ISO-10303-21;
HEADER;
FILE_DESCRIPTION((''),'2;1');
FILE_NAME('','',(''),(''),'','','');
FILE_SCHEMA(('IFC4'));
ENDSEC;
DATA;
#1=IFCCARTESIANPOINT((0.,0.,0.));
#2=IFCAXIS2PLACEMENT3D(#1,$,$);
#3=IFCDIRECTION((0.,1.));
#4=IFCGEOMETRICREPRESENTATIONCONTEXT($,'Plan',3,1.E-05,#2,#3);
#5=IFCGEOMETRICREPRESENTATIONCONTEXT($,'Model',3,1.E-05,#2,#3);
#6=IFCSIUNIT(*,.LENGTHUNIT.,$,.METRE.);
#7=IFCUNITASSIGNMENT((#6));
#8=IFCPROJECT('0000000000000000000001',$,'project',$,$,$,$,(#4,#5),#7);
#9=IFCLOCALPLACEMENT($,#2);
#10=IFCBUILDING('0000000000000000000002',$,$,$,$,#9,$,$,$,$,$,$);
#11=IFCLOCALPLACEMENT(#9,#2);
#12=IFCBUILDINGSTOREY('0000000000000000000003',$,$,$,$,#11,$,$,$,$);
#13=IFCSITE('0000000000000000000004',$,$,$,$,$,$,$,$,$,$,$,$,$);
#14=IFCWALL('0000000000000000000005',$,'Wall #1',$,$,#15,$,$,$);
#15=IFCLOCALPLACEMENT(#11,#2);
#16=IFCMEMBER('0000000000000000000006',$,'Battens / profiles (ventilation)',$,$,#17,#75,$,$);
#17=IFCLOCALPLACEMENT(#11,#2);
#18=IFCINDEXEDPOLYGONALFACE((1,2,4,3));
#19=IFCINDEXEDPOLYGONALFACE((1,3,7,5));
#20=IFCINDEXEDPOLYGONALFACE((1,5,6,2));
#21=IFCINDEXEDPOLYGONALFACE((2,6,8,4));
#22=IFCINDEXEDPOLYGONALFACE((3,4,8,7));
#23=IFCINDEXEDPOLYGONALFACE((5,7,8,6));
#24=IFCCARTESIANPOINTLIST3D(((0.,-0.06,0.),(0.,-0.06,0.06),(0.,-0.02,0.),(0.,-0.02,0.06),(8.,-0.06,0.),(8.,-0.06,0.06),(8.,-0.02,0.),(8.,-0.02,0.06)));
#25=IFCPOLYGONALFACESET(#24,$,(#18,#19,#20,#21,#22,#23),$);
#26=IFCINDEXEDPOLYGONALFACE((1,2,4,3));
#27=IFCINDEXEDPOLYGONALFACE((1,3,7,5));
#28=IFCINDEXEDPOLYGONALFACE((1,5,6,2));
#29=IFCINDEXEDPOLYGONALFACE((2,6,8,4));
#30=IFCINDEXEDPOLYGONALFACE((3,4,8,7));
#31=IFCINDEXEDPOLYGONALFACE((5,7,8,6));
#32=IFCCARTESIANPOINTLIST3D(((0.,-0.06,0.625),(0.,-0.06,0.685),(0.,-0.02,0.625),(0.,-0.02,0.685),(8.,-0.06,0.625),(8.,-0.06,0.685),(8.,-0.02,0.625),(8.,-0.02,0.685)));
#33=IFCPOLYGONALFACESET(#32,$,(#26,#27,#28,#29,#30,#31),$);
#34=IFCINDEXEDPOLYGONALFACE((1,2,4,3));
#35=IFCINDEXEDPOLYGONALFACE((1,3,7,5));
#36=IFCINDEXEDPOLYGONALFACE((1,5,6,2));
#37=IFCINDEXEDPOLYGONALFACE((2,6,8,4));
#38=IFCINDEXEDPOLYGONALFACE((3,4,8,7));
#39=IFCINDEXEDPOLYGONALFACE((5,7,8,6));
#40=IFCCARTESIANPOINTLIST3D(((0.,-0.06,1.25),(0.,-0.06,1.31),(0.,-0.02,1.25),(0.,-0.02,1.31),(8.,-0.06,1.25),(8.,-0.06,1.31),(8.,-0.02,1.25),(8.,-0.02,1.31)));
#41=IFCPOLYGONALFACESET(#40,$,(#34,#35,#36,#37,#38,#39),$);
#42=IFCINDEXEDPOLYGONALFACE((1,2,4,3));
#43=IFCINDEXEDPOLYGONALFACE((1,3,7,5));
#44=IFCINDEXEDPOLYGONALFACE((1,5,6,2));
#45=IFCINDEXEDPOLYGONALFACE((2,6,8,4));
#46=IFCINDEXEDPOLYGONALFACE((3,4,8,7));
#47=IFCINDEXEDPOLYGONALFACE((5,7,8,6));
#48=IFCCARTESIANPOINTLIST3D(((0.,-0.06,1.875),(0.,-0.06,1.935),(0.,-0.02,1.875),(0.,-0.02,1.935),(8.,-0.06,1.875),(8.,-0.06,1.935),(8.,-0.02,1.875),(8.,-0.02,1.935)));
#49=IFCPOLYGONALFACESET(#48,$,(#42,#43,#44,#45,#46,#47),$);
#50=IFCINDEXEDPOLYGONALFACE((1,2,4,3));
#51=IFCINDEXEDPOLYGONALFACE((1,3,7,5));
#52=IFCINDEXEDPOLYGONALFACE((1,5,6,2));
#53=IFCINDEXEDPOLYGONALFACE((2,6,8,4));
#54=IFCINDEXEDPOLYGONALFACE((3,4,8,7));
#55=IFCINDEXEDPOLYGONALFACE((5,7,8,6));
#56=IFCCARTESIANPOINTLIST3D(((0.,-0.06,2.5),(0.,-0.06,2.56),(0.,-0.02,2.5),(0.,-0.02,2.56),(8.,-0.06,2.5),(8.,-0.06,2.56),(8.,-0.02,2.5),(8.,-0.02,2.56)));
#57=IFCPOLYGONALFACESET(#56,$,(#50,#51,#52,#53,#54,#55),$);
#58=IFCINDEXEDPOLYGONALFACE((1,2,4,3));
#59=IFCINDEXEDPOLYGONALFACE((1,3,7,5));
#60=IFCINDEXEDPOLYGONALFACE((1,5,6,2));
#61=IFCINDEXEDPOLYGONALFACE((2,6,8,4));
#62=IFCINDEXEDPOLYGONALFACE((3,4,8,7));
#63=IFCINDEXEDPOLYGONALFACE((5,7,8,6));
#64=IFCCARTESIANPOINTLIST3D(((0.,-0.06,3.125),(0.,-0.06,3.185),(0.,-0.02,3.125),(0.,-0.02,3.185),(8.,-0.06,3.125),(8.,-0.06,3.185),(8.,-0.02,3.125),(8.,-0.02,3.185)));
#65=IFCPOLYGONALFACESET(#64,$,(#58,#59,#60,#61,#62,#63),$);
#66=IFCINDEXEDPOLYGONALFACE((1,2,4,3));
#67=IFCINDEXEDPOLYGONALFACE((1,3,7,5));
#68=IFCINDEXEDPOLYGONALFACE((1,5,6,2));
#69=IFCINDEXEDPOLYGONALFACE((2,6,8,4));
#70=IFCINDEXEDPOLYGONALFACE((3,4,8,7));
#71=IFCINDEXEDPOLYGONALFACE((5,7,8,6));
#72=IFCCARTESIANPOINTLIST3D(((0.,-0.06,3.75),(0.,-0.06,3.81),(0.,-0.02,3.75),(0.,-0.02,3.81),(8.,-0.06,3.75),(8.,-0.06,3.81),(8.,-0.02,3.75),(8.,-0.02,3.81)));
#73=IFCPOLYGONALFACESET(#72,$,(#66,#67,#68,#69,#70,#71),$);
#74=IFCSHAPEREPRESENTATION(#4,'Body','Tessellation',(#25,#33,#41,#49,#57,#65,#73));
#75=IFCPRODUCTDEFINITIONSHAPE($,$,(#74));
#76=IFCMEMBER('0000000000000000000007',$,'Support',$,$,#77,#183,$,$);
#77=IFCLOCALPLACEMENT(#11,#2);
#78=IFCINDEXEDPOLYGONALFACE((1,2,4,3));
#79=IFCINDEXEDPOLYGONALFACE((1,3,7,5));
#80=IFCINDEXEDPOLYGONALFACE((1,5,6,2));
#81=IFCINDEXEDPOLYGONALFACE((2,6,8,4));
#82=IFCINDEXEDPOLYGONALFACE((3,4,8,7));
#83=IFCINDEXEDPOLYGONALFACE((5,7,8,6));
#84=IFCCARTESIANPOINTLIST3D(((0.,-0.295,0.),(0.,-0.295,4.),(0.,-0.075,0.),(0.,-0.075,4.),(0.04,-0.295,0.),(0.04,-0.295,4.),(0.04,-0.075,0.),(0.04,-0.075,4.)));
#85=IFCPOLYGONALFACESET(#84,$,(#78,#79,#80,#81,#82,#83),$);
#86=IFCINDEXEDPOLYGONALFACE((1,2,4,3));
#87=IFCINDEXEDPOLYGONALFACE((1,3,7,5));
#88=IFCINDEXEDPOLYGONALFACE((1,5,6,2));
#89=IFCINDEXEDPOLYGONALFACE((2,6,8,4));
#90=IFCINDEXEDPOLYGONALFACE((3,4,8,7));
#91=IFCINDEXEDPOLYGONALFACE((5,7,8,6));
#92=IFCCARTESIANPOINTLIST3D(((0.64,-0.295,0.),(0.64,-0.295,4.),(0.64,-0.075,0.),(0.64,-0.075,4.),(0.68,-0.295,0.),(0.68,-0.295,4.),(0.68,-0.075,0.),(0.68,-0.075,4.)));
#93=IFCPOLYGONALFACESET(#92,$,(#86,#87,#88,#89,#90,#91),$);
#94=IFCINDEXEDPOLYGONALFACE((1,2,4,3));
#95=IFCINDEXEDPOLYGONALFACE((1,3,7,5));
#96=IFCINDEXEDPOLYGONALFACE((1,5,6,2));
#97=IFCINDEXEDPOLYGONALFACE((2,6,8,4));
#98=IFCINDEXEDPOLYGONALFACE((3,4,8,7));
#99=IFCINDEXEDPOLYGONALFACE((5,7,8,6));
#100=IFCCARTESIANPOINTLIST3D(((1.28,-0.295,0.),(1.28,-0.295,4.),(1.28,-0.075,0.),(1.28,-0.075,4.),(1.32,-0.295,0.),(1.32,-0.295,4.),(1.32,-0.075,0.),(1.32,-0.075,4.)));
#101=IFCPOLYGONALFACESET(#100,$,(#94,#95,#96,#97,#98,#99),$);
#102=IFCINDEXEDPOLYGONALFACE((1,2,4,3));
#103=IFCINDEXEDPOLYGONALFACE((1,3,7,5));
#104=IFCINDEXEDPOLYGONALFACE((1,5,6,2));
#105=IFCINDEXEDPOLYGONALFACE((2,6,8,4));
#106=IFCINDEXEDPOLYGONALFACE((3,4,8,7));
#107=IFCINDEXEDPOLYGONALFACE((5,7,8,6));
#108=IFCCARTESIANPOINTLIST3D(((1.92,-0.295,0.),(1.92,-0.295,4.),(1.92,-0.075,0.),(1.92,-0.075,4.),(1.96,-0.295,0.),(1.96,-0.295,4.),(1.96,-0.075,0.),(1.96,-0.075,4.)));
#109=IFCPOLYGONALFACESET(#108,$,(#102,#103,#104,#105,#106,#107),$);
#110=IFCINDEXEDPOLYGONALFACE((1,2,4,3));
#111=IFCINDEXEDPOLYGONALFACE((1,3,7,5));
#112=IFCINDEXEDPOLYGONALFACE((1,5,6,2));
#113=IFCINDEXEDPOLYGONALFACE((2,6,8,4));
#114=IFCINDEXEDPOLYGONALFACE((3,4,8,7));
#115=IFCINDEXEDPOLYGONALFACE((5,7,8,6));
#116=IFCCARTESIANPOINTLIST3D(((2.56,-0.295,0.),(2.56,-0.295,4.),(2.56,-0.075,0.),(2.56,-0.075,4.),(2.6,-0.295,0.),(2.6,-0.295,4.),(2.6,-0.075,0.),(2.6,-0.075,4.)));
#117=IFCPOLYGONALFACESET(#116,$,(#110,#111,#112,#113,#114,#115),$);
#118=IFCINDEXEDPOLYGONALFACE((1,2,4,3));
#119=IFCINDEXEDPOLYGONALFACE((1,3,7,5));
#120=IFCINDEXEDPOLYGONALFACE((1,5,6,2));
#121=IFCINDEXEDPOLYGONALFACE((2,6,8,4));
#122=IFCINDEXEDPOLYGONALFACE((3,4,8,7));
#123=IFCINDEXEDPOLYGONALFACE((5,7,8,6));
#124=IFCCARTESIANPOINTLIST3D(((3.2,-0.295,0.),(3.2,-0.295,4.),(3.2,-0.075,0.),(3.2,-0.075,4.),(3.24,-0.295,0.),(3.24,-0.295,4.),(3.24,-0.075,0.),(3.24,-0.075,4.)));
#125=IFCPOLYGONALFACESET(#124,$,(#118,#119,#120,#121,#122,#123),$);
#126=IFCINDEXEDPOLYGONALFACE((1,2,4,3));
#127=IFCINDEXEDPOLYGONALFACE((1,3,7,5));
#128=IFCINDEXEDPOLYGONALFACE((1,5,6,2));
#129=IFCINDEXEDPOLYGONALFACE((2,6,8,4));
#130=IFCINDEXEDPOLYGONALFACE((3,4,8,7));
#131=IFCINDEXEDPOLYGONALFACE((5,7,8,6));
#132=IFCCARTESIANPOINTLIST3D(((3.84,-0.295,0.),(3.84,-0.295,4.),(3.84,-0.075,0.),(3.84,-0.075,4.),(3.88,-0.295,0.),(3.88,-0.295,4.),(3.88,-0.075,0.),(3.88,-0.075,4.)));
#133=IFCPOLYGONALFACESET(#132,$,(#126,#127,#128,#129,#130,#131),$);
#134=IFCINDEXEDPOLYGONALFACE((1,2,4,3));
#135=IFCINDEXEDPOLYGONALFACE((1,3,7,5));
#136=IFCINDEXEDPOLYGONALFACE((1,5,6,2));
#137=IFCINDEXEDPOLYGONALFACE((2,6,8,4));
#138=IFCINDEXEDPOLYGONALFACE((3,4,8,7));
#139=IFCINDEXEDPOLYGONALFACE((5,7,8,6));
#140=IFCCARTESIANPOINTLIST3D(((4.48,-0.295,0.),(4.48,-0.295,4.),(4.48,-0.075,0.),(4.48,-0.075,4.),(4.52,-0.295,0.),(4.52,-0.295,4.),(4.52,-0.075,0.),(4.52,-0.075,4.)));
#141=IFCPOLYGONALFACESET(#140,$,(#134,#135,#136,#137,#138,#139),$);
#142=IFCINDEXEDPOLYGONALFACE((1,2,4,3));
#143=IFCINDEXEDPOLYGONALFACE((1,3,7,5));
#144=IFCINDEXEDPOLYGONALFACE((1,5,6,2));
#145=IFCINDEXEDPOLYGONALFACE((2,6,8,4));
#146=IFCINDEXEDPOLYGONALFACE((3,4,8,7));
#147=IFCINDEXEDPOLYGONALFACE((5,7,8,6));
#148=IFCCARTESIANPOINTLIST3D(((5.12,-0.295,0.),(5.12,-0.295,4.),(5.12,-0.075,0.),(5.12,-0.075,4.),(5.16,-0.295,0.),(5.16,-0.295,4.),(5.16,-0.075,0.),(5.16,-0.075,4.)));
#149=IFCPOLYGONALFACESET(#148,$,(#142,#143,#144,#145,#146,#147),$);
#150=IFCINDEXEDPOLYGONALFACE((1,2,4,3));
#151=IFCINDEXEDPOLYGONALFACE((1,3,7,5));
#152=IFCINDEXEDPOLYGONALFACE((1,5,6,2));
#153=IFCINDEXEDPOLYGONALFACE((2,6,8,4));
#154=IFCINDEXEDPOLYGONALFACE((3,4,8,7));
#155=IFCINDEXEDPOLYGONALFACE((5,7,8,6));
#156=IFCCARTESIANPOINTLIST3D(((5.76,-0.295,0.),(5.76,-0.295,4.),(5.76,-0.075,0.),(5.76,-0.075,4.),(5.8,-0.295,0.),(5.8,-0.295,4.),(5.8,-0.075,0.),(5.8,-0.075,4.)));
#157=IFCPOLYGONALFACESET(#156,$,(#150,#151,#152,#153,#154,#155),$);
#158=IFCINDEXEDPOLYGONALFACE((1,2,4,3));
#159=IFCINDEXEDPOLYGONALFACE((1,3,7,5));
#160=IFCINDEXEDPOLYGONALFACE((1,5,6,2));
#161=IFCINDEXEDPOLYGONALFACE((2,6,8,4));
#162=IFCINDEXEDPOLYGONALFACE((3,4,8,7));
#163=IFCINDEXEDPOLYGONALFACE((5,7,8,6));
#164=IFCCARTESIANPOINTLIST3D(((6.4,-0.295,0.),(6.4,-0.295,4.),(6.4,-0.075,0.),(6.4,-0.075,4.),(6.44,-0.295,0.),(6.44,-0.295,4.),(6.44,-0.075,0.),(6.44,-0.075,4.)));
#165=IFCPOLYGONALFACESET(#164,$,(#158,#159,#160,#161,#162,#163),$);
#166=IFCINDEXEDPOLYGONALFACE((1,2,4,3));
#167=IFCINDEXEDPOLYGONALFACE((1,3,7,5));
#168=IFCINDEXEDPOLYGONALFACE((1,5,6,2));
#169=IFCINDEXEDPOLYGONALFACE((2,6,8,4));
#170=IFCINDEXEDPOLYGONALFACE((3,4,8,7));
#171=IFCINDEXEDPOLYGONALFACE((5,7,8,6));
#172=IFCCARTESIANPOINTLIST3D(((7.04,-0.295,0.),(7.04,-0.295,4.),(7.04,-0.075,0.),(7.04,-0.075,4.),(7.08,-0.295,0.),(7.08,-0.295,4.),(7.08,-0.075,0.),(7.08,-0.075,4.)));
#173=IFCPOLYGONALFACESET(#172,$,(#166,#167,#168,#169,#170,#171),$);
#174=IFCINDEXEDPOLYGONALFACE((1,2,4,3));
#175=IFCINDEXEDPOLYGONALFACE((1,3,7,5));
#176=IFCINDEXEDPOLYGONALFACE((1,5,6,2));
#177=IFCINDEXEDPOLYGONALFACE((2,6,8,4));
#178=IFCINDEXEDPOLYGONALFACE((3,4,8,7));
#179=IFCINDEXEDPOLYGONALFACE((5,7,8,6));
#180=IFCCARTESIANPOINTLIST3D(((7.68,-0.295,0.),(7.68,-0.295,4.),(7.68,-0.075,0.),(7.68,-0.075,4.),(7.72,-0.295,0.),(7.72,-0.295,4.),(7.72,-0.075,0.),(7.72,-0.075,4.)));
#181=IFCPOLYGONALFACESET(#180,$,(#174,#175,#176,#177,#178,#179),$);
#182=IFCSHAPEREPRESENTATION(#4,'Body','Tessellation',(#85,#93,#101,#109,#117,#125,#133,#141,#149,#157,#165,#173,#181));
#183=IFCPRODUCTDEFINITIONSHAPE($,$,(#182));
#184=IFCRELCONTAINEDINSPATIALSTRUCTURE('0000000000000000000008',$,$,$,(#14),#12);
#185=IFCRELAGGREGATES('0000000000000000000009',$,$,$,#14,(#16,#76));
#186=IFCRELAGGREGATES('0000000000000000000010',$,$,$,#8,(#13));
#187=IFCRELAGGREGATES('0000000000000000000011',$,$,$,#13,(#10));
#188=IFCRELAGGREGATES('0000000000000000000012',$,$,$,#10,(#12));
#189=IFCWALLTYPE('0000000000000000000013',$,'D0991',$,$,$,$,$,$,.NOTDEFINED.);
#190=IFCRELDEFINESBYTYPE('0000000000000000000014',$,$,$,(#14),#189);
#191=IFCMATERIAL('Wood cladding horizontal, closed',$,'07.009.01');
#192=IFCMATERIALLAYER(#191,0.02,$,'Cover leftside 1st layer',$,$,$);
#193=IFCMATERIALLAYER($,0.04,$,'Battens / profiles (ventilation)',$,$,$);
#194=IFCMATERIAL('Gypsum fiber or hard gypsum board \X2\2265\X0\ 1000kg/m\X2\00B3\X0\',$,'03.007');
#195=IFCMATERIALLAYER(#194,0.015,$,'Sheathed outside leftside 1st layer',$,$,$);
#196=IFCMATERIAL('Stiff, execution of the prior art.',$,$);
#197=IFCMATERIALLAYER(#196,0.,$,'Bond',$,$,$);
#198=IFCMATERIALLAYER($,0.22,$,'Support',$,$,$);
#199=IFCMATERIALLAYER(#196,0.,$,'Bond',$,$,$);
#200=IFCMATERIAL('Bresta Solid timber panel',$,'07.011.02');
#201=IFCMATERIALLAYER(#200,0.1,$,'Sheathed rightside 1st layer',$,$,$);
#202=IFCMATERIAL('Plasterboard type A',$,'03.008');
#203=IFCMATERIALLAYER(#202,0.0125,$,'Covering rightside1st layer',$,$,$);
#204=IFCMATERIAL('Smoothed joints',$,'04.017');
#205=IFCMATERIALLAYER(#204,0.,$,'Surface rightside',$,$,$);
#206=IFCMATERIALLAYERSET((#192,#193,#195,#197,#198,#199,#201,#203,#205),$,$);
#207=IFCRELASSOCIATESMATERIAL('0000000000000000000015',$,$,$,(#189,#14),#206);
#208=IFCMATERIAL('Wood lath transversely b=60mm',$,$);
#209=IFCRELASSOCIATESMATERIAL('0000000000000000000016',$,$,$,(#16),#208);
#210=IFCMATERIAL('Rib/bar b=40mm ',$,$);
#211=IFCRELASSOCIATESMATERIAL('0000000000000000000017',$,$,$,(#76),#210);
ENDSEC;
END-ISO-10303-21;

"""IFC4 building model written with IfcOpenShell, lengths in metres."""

from ifc_helpers import new_model, si_unit, direction, frame, frame_2d, origin, place, context, project, spatial, rectangle, extrude, material, layer, layer_set, type_object, element, aggregate, save


model = new_model("IFC4")

# Units and contexts
plan_context = context("Plan", 3, precision=1e-05, world=origin(), true_north=direction((0.0, 1.0)))
model_context = context("Model", 3, precision=1e-05, world=origin(), true_north=direction((0.0, 1.0)))
ifc_project = project(units=[si_unit("LENGTHUNIT", "METRE")], contexts=[plan_context, model_context])

# Site, building, storey
site = spatial("IfcSite", under=ifc_project)
building_placement = place(None, origin())
building = spatial("IfcBuilding", under=site, at=building_placement)
storey_placement = place(building_placement, origin())
storey = spatial("IfcBuildingStorey", under=building, at=storey_placement)

# Wall, members
ifc_material_1 = material(Name="Wood cladding horizontal, closed", Category="07.009.01")
ifc_layer_1 = layer(ifc_material_1, 0.02, Name="Cover leftside 1st layer")
ifc_layer_2 = layer(None, 0.04, Name="Battens / profiles (ventilation)")
ifc_material_2 = material(Name="Gypsum fiber or hard gypsum board ≥ 1000kg/m³", Category="03.007")
ifc_layer_3 = layer(ifc_material_2, 0.015, Name="Sheathed outside leftside 1st layer")
ifc_material_3 = material(Name="Stiff, execution of the prior art.")
ifc_layer_4 = layer(ifc_material_3, 0.0, Name="Bond")
ifc_layer_5 = layer(None, 0.22, Name="Support")
ifc_layer_6 = layer(ifc_material_3, 0.0, Name="Bond")
ifc_material_4 = material(Name="Bresta Solid timber panel", Category="07.011.02")
ifc_layer_7 = layer(ifc_material_4, 0.1, Name="Sheathed rightside 1st layer")
ifc_material_5 = material(Name="Plasterboard type A", Category="03.008")
ifc_layer_8 = layer(ifc_material_5, 0.0125, Name="Covering rightside1st layer")
ifc_material_6 = material(Name="Smoothed joints", Category="04.017")
ifc_layer_9 = layer(ifc_material_6, 0.0, Name="Surface rightside")
ifc_layer_set = layer_set([ifc_layer_1, ifc_layer_2, ifc_layer_3, ifc_layer_4, ifc_layer_5, ifc_layer_6, ifc_layer_7, ifc_layer_8, ifc_layer_9])
wall_type = type_object("IfcWallType", Name="D0991", PredefinedType="NOTDEFINED", material=ifc_layer_set)
wall_placement = place(None, frame((0.0, 0.0, 0.0), z_axis=(0.0, -1.0, 0.0), x_axis=(1.0, 0.0, 0.0)))
wall = element("IfcWall", 1, at=wall_placement, inside=storey, type_object=wall_type, material=ifc_layer_set, Name="Wall #1")
ifc_material_7 = material(Name="Wood lath transversely b=60mm")
member_1_placement = place(wall_placement, origin())
member_1 = element("IfcMember", 2, at=member_1_placement, material=ifc_material_7, Name="Battens / profiles (ventilation)", context=plan_context, shape_type="SweptSolid", body=[
    extrude(rectangle(XDim=0.06, YDim=0.04, at=frame_2d((0.03, 0.02), x_axis=(1.0, 0.0))), frame((0.0, 0.0, 0.02), z_axis=(1.0, 0.0, 0.0), x_axis=(0.0, 1.0, 0.0)), (0.0, 0.0, 1.0), 8.0),
    extrude(rectangle(XDim=0.06, YDim=0.04, at=frame_2d((0.03, 0.02), x_axis=(1.0, 0.0))), frame((0.0, 0.625, 0.02), z_axis=(1.0, 0.0, 0.0), x_axis=(0.0, 1.0, 0.0)), (0.0, 0.0, 1.0), 8.0),
    extrude(rectangle(XDim=0.06, YDim=0.04, at=frame_2d((0.03, 0.02), x_axis=(1.0, 0.0))), frame((0.0, 1.25, 0.02), z_axis=(1.0, 0.0, 0.0), x_axis=(0.0, 1.0, 0.0)), (0.0, 0.0, 1.0), 8.0),
    extrude(rectangle(XDim=0.06, YDim=0.04, at=frame_2d((0.03, 0.02), x_axis=(1.0, 0.0))), frame((0.0, 1.875, 0.02), z_axis=(1.0, 0.0, 0.0), x_axis=(0.0, 1.0, 0.0)), (0.0, 0.0, 1.0), 8.0),
    extrude(rectangle(XDim=0.06, YDim=0.04, at=frame_2d((0.03, 0.02), x_axis=(1.0, 0.0))), frame((0.0, 2.5, 0.02), z_axis=(1.0, 0.0, 0.0), x_axis=(0.0, 1.0, 0.0)), (0.0, 0.0, 1.0), 8.0),
    extrude(rectangle(XDim=0.06, YDim=0.04, at=frame_2d((0.03, 0.02), x_axis=(1.0, 0.0))), frame((0.0, 3.125, 0.02), z_axis=(1.0, 0.0, 0.0), x_axis=(0.0, 1.0, 0.0)), (0.0, 0.0, 1.0), 8.0),
    extrude(rectangle(XDim=0.06, YDim=0.04, at=frame_2d((0.03, 0.02), x_axis=(1.0, 0.0))), frame((0.0, 3.75, 0.02), z_axis=(1.0, 0.0, 0.0), x_axis=(0.0, 1.0, 0.0)), (0.0, 0.0, 1.0), 8.0),
])
ifc_material_8 = material(Name="Rib/bar b=40mm ")
member_2_placement = place(wall_placement, origin())
member_2 = element("IfcMember", 3, at=member_2_placement, material=ifc_material_8, Name="Support", context=plan_context, shape_type="SweptSolid", body=[
    extrude(rectangle(XDim=0.04, YDim=0.22, at=frame_2d((0.02, 0.11), x_axis=(1.0, 0.0))), frame((0.0, 4.0, 0.075), z_axis=(0.0, -1.0, 0.0), x_axis=(1.0, 0.0, 0.0)), (0.0, 0.0, 1.0), 4.0),
    extrude(rectangle(XDim=0.04, YDim=0.22, at=frame_2d((0.02, 0.11), x_axis=(1.0, 0.0))), frame((0.64, 4.0, 0.075), z_axis=(0.0, -1.0, 0.0), x_axis=(1.0, 0.0, 0.0)), (0.0, 0.0, 1.0), 4.0),
    extrude(rectangle(XDim=0.04, YDim=0.22, at=frame_2d((0.02, 0.11), x_axis=(1.0, 0.0))), frame((1.28, 4.0, 0.075), z_axis=(0.0, -1.0, 0.0), x_axis=(1.0, 0.0, 0.0)), (0.0, 0.0, 1.0), 4.0),
    extrude(rectangle(XDim=0.04, YDim=0.22, at=frame_2d((0.02, 0.11), x_axis=(1.0, 0.0))), frame((1.92, 4.0, 0.075), z_axis=(0.0, -1.0, 0.0), x_axis=(1.0, 0.0, 0.0)), (0.0, 0.0, 1.0), 4.0),
    extrude(rectangle(XDim=0.04, YDim=0.22, at=frame_2d((0.02, 0.11), x_axis=(1.0, 0.0))), frame((2.56, 4.0, 0.075), z_axis=(0.0, -1.0, 0.0), x_axis=(1.0, 0.0, 0.0)), (0.0, 0.0, 1.0), 4.0),
    extrude(rectangle(XDim=0.04, YDim=0.22, at=frame_2d((0.02, 0.11), x_axis=(1.0, 0.0))), frame((3.2, 4.0, 0.075), z_axis=(0.0, -1.0, 0.0), x_axis=(1.0, 0.0, 0.0)), (0.0, 0.0, 1.0), 4.0),
    extrude(rectangle(XDim=0.04, YDim=0.22, at=frame_2d((0.02, 0.11), x_axis=(1.0, 0.0))), frame((3.84, 4.0, 0.075), z_axis=(0.0, -1.0, 0.0), x_axis=(1.0, 0.0, 0.0)), (0.0, 0.0, 1.0), 4.0),
    extrude(rectangle(XDim=0.04, YDim=0.22, at=frame_2d((0.02, 0.11), x_axis=(1.0, 0.0))), frame((4.48, 4.0, 0.075), z_axis=(0.0, -1.0, 0.0), x_axis=(1.0, 0.0, 0.0)), (0.0, 0.0, 1.0), 4.0),
    extrude(rectangle(XDim=0.04, YDim=0.22, at=frame_2d((0.02, 0.11), x_axis=(1.0, 0.0))), frame((5.12, 4.0, 0.075), z_axis=(0.0, -1.0, 0.0), x_axis=(1.0, 0.0, 0.0)), (0.0, 0.0, 1.0), 4.0),
    extrude(rectangle(XDim=0.04, YDim=0.22, at=frame_2d((0.02, 0.11), x_axis=(1.0, 0.0))), frame((5.76, 4.0, 0.075), z_axis=(0.0, -1.0, 0.0), x_axis=(1.0, 0.0, 0.0)), (0.0, 0.0, 1.0), 4.0),
    extrude(rectangle(XDim=0.04, YDim=0.22, at=frame_2d((0.02, 0.11), x_axis=(1.0, 0.0))), frame((6.4, 4.0, 0.075), z_axis=(0.0, -1.0, 0.0), x_axis=(1.0, 0.0, 0.0)), (0.0, 0.0, 1.0), 4.0),
    extrude(rectangle(XDim=0.04, YDim=0.22, at=frame_2d((0.02, 0.11), x_axis=(1.0, 0.0))), frame((7.04, 4.0, 0.075), z_axis=(0.0, -1.0, 0.0), x_axis=(1.0, 0.0, 0.0)), (0.0, 0.0, 1.0), 4.0),
    extrude(rectangle(XDim=0.04, YDim=0.22, at=frame_2d((0.02, 0.11), x_axis=(1.0, 0.0))), frame((7.68, 4.0, 0.075), z_axis=(0.0, -1.0, 0.0), x_axis=(1.0, 0.0, 0.0)), (0.0, 0.0, 1.0), 4.0),
])
aggregate(wall, [member_1, member_2])

save(model, "model.ifc")
